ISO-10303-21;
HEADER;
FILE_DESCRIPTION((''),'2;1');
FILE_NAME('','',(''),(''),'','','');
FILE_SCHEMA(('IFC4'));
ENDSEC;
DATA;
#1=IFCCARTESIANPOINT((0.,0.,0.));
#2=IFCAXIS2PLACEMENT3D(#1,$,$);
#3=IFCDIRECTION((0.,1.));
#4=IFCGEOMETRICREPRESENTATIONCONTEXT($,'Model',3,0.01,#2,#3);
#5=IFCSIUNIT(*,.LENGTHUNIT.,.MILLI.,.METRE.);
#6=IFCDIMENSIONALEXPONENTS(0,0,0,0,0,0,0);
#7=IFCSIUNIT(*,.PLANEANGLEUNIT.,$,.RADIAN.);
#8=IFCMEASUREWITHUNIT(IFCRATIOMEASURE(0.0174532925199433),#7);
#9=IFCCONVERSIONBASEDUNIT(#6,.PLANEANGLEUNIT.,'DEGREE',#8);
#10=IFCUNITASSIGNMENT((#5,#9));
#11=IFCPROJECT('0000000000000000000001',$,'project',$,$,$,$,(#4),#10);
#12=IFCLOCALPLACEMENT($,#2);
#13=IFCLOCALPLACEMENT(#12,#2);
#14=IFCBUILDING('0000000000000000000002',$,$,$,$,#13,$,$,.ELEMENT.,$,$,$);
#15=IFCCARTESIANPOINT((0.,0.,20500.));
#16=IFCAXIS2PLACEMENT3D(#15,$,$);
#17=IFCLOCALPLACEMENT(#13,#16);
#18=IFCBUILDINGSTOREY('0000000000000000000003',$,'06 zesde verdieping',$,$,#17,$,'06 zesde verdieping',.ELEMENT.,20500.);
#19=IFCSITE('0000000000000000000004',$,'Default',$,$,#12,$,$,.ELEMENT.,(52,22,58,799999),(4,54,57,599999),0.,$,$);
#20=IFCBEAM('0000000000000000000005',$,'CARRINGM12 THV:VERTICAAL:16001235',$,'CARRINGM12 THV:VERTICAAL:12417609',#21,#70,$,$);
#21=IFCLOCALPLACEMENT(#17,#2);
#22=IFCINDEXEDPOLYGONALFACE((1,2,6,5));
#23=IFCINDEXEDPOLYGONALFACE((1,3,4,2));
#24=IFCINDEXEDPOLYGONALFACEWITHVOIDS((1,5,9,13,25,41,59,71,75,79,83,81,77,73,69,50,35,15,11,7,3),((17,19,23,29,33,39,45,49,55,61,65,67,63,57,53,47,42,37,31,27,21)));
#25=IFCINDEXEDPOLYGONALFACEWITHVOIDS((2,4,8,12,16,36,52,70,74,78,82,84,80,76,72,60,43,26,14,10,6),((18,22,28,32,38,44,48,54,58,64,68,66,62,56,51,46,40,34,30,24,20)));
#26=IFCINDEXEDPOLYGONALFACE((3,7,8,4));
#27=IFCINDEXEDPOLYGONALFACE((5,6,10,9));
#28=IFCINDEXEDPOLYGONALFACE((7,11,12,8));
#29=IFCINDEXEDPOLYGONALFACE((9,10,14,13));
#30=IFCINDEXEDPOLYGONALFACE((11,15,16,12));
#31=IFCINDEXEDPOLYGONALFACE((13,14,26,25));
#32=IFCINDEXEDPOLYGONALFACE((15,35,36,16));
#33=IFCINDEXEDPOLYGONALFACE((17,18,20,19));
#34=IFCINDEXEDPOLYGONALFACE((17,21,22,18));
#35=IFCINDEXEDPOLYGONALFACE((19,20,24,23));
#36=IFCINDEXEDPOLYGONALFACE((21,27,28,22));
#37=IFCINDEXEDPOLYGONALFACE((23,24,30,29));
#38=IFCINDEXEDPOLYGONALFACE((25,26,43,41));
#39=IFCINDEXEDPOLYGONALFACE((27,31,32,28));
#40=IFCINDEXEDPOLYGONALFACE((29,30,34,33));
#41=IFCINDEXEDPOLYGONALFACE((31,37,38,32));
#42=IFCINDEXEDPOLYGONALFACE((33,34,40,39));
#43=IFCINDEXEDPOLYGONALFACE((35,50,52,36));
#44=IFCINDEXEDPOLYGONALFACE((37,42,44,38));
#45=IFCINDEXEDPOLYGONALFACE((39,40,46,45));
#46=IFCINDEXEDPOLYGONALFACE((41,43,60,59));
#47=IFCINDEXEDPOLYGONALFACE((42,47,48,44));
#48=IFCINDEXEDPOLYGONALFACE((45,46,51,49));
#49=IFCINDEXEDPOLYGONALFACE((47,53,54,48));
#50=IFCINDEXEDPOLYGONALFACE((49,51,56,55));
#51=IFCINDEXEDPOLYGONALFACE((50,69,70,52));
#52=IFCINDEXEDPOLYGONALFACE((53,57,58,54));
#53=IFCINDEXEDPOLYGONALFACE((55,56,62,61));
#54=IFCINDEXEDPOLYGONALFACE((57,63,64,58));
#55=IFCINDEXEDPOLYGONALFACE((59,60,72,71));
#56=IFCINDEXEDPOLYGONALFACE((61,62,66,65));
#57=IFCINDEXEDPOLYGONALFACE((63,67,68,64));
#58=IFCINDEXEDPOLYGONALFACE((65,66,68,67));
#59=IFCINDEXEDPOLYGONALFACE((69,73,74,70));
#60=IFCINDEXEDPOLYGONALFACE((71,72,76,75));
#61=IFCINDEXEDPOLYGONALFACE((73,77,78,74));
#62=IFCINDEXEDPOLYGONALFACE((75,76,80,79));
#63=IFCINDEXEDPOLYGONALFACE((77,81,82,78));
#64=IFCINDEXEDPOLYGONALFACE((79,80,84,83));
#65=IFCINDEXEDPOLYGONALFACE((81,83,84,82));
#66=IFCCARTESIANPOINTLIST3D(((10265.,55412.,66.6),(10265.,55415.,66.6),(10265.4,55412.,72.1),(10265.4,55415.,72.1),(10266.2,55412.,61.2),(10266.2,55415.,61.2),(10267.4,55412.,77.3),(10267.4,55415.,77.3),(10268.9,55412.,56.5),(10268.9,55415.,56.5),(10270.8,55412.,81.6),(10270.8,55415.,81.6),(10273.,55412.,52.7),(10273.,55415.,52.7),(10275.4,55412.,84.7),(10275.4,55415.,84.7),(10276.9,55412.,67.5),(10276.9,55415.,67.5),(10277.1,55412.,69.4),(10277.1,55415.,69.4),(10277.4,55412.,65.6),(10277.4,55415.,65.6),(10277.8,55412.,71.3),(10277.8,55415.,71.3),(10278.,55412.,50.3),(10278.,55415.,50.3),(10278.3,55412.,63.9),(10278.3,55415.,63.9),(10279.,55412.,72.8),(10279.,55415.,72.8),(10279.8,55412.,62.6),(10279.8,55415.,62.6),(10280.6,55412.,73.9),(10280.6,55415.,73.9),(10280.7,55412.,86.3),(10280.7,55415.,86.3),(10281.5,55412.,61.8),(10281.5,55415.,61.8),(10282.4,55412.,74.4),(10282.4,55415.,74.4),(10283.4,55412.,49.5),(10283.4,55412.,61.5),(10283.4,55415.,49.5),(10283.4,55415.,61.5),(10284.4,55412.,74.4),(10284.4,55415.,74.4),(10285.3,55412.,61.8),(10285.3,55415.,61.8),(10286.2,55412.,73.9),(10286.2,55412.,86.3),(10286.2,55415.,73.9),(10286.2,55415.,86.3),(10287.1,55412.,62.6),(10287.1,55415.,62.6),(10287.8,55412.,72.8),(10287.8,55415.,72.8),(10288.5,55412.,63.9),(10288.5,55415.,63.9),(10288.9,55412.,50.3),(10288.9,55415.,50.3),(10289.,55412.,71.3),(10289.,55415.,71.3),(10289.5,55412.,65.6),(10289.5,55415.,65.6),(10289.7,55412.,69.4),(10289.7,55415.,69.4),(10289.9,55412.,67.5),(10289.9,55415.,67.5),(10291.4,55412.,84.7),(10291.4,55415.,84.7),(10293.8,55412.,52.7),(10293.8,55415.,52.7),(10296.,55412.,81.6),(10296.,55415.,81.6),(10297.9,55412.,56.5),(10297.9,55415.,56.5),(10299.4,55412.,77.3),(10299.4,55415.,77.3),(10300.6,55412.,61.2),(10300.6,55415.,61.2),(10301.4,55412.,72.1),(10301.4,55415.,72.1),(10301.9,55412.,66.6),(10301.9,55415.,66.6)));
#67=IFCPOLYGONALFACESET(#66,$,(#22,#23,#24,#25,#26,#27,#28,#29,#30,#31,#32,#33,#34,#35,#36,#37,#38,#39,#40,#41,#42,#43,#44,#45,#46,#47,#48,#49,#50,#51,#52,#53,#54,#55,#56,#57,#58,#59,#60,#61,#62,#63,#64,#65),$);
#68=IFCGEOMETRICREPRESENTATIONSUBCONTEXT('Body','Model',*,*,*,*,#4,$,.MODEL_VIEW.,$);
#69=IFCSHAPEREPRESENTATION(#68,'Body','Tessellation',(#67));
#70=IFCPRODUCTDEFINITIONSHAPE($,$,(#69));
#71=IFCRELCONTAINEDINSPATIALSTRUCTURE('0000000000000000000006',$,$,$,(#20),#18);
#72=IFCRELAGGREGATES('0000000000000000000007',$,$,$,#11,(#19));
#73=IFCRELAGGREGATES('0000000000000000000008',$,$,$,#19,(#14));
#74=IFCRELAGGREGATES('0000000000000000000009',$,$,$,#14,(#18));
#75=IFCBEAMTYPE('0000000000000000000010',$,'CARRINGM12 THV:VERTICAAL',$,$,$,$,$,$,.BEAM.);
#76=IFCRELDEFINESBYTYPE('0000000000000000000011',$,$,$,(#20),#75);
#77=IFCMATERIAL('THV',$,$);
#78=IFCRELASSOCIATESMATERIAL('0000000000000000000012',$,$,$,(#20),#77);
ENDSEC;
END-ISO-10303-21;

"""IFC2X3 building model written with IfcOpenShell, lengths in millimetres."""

from ifc_helpers import new_model, entity, si_unit, converted_unit, direction, frame, origin, origin_2d_with_axis, place, context, subcontext, project, spatial, hollow_circle, extrude, material, type_object, element, save


model = new_model("IFC2X3")

# Units and contexts
model_context = context("Model", 3, precision=0.01, world=origin(), true_north=direction((0.0, 1.0)))
body_context = subcontext(model_context, "Body", "Model", "MODEL_VIEW")
ifc_project = project(units=[si_unit("LENGTHUNIT", "METRE", prefix="MILLI"), converted_unit("PLANEANGLEUNIT", "DEGREE", entity("IfcRatioMeasure", 0.0174532925199433), si_unit("PLANEANGLEUNIT", "RADIAN"), dimensions=[0, 0, 0, 0, 0, 0, 0])], contexts=[model_context])

# Site, building, storey
site_placement = place(None, origin())
site = spatial("IfcSite", under=ifc_project, at=site_placement, Name="Default", CompositionType="ELEMENT", RefLatitude=(52, 22, 58, 799999), RefLongitude=(4, 54, 57, 599999), RefElevation=0.0)
building_placement = place(site_placement, origin())
building = spatial("IfcBuilding", under=site, at=building_placement, CompositionType="ELEMENT")
storey_placement = place(building_placement, frame((0.0, 0.0, 20500.0)))
storey = spatial("IfcBuildingStorey", under=building, at=storey_placement, Name="06 zesde verdieping", LongName="06 zesde verdieping", CompositionType="ELEMENT", Elevation=20500.0)

# Beam
ifc_material_1 = material(Name="THV")
beam_type_1 = type_object("IfcBeamType", Name="CARRINGM12 THV:VERTICAAL", PredefinedType="BEAM")
beam_1_placement = place(storey_placement, origin())
element("IfcBeam", 1, at=beam_1_placement, inside=storey, type_object=beam_type_1, material=ifc_material_1, Name="CARRINGM12 THV:VERTICAAL:16001235", ObjectType="CARRINGM12 THV:VERTICAAL:12417609", context=body_context, shape_type="SweptSolid", body=[
    extrude(hollow_circle(Radius=18.5, WallThickness=12.0, at=origin_2d_with_axis()), frame((10283.4, 55412.0, 68.0), z_axis=(0.0, 1.0, 0.0), x_axis=(0.0, 0.0, -1.0)), (0.0, 0.0, 1.0), 3.0),
])

save(model, "model.ifc")
